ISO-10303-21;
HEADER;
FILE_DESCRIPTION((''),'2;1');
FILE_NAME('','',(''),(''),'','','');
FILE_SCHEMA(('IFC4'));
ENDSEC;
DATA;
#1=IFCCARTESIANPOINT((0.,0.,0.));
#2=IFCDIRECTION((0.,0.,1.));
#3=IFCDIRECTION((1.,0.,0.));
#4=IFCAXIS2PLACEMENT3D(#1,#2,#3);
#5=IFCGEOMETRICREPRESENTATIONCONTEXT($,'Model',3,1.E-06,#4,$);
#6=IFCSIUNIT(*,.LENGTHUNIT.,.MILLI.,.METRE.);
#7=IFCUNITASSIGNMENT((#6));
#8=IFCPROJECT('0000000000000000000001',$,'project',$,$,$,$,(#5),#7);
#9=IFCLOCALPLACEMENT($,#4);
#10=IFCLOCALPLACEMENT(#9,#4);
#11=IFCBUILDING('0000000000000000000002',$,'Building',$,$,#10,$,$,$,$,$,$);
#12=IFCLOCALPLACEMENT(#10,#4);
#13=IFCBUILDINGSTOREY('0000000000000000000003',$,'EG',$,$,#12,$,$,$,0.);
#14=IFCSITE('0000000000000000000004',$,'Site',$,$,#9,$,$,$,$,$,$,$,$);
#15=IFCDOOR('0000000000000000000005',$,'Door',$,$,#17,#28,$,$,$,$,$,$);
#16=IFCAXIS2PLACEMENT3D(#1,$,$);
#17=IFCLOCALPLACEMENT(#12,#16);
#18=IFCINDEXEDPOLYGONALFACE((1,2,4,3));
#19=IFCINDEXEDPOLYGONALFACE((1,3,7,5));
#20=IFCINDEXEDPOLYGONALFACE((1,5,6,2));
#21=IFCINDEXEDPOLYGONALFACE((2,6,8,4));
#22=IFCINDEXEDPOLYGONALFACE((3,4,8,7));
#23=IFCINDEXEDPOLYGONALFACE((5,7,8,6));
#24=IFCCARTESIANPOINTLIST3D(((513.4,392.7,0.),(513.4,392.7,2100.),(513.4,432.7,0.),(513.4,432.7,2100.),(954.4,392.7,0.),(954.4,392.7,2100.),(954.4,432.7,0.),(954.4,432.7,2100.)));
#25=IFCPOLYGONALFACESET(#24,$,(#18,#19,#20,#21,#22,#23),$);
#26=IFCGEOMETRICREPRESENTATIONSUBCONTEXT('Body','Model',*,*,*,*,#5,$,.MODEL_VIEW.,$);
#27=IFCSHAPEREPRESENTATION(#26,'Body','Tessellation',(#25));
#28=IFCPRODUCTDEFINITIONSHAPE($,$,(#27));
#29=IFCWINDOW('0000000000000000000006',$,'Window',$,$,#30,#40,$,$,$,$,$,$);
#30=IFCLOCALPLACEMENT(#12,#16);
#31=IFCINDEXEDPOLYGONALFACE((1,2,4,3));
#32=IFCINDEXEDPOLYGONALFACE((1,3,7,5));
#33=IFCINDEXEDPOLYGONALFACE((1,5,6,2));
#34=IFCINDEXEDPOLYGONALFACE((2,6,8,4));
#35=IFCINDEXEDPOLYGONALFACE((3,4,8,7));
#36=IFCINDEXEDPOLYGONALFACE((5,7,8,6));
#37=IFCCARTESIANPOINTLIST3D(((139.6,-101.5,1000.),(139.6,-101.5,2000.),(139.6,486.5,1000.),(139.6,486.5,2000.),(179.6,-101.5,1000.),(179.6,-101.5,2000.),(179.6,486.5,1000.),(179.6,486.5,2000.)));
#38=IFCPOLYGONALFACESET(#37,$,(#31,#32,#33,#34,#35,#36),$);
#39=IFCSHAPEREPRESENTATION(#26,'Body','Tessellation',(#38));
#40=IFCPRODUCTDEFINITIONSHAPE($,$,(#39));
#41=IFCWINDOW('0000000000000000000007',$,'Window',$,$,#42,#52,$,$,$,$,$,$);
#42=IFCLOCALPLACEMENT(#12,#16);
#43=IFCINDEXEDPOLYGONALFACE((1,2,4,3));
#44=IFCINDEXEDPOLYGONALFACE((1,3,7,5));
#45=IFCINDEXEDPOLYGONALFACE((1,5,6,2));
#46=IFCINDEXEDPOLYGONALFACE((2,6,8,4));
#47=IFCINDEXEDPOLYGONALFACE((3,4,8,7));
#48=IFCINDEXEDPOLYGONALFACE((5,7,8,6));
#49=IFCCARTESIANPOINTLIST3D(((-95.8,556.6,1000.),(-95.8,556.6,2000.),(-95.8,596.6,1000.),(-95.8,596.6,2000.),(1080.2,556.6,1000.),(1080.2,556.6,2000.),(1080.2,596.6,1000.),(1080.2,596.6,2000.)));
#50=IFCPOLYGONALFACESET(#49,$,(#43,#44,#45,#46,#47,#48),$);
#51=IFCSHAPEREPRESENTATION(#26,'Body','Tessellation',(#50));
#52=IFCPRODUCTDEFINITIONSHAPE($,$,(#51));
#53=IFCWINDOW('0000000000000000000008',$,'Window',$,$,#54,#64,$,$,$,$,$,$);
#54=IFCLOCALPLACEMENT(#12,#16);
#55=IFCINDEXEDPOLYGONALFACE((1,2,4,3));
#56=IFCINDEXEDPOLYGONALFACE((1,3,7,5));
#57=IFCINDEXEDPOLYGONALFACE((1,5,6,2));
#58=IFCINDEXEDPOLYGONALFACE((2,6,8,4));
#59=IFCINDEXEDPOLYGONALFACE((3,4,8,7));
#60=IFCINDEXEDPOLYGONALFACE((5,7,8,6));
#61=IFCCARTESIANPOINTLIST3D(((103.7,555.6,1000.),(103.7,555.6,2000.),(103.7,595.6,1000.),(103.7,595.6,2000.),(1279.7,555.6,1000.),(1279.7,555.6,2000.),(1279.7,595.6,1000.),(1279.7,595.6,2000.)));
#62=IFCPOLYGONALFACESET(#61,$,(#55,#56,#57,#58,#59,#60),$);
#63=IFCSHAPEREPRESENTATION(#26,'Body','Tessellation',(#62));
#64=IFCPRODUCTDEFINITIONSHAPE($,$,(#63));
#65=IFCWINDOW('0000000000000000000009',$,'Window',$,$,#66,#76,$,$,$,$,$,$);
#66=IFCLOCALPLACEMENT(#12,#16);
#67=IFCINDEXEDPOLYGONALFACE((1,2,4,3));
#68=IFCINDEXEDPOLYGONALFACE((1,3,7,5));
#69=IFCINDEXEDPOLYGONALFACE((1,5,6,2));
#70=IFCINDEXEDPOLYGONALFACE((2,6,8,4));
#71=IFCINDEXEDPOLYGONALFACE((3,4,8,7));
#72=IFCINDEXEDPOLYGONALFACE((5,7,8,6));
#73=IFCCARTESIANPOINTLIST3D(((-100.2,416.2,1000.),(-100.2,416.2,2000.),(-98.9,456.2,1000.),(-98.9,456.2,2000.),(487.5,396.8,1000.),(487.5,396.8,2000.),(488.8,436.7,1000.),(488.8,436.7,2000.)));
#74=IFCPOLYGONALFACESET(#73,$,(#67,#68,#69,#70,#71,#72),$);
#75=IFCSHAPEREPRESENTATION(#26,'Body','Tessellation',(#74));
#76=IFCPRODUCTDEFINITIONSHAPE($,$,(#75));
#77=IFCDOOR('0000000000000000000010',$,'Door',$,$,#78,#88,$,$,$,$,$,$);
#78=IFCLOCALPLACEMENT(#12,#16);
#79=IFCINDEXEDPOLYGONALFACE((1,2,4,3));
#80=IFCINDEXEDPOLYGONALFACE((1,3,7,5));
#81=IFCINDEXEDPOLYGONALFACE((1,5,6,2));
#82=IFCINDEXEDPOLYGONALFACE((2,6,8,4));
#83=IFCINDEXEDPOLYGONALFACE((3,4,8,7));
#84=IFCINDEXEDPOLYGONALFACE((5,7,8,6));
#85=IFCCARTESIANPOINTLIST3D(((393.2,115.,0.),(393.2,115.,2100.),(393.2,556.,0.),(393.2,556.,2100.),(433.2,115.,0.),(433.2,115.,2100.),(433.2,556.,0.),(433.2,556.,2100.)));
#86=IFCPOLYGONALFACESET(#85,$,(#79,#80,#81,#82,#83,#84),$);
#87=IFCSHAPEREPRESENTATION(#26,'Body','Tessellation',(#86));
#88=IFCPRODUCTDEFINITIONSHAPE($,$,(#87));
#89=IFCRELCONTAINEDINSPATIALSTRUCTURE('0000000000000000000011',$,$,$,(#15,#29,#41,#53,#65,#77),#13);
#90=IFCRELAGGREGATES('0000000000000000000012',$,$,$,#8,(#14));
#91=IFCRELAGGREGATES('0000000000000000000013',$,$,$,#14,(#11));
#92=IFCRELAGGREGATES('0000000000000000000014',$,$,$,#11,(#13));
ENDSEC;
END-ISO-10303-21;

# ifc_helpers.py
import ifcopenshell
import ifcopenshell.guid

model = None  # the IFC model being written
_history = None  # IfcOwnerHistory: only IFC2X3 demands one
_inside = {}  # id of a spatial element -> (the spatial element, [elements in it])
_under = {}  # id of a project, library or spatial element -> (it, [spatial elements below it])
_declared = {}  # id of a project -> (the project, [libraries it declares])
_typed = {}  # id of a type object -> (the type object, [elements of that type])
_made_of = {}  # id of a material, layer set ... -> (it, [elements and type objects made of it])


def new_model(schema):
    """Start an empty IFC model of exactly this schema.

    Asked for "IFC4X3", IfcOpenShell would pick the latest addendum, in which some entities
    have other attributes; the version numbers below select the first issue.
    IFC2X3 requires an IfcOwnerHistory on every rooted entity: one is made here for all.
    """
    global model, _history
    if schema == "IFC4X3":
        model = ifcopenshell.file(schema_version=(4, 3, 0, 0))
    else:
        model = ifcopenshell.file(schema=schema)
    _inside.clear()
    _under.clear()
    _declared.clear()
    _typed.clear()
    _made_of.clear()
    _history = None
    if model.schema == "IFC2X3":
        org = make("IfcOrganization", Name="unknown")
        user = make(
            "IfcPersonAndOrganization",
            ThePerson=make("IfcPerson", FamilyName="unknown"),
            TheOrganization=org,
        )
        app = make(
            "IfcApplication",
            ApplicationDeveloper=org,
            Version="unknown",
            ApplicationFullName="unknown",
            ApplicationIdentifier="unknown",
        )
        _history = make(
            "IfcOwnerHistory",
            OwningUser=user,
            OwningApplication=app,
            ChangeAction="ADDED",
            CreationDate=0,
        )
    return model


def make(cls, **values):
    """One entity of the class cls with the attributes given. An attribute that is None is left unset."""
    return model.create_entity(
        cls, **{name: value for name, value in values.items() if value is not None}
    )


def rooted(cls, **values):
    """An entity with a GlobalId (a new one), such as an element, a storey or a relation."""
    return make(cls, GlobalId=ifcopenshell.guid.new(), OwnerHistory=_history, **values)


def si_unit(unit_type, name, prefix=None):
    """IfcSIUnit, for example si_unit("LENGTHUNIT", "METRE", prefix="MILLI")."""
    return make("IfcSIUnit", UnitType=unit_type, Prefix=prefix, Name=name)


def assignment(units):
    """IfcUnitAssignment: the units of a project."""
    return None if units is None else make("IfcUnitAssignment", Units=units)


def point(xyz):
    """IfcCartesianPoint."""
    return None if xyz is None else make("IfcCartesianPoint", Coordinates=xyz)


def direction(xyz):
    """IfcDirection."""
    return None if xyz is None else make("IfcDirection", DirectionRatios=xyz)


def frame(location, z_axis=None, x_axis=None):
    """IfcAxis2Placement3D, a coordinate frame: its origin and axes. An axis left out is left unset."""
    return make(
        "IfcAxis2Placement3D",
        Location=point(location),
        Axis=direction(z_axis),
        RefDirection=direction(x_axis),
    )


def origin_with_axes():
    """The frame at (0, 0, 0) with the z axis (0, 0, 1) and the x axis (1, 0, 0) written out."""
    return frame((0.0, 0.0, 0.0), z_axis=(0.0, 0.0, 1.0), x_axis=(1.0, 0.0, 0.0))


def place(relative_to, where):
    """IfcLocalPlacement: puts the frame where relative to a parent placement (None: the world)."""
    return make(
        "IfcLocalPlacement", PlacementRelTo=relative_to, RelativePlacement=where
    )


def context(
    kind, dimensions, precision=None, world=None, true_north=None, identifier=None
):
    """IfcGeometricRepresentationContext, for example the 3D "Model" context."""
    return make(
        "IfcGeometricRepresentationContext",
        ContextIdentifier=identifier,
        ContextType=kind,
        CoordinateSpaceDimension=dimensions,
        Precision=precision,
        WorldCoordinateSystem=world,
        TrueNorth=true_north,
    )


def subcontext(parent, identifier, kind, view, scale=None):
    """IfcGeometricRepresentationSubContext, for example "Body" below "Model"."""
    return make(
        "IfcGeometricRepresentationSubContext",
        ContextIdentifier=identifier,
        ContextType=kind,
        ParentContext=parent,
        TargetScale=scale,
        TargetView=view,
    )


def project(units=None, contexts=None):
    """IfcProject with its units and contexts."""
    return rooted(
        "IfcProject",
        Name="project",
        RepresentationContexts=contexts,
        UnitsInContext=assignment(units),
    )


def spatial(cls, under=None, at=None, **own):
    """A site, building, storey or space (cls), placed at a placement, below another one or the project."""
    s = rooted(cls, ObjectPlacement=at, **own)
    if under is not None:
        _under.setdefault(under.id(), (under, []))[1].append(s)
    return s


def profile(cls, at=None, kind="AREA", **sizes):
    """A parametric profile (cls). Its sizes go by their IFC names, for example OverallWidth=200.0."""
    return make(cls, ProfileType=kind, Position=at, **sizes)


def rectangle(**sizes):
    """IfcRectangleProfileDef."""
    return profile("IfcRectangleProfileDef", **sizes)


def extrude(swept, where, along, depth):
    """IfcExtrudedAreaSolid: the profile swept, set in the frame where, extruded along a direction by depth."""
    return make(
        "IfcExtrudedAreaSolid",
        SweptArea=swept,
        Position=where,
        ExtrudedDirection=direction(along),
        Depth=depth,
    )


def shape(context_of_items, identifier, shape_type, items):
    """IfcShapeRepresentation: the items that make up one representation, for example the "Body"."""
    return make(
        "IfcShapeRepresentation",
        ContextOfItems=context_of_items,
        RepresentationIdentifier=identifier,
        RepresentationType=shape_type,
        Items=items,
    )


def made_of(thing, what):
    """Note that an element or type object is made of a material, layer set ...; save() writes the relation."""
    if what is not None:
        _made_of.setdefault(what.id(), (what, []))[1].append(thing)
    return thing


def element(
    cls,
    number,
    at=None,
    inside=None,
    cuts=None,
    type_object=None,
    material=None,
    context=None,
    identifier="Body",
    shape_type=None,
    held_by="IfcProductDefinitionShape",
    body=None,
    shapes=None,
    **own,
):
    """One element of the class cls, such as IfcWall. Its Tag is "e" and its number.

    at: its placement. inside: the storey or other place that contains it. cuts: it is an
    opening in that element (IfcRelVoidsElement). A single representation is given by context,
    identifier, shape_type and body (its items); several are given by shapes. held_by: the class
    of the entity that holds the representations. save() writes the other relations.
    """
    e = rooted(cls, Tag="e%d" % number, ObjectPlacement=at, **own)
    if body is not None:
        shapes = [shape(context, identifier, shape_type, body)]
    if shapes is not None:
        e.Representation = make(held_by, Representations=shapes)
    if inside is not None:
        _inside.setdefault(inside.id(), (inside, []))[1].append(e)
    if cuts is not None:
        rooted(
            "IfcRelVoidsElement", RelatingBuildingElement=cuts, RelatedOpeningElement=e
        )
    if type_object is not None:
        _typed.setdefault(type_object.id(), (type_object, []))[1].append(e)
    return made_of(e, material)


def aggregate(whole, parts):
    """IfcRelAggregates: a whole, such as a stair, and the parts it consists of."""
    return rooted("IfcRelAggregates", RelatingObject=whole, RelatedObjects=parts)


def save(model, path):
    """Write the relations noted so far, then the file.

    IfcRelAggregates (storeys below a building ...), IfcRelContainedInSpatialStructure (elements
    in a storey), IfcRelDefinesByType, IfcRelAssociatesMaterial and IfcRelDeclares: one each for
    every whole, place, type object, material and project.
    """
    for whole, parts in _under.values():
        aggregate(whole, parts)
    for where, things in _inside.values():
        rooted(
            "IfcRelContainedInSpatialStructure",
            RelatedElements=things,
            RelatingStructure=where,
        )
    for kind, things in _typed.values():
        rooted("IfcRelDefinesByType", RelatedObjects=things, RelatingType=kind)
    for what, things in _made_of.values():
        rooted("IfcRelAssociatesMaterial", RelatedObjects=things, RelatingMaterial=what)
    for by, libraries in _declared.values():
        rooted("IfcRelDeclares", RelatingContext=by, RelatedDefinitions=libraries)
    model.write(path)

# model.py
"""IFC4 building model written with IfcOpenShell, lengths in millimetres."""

from ifc_helpers import new_model, si_unit, frame, origin_with_axes, place, context, subcontext, project, spatial, rectangle, extrude, element, save


model = new_model("IFC4")

# Units and contexts
model_context = context("Model", 3, precision=1e-06, world=origin_with_axes())
body_context = subcontext(model_context, "Body", "Model", "MODEL_VIEW")
ifc_project = project(units=[si_unit("LENGTHUNIT", "METRE", prefix="MILLI")], contexts=[model_context])

# Site, building, storey
site_placement = place(None, origin_with_axes())
site = spatial("IfcSite", under=ifc_project, at=site_placement, Name="Site")
building_placement = place(site_placement, origin_with_axes())
building = spatial("IfcBuilding", under=site, at=building_placement, Name="Building")
storey_placement = place(building_placement, origin_with_axes())
storey = spatial("IfcBuildingStorey", under=building, at=storey_placement, Name="EG", Elevation=0.0)

# Door
door_1_placement = place(storey_placement, origin_with_axes())
element("IfcDoor", 1, at=door_1_placement, inside=storey, Name="Door", context=body_context, shape_type="SweptSolid", body=[
    extrude(rectangle(XDim=441.0, YDim=40.0), frame((733.9, 412.7, 0.0), z_axis=(0.0, 0.0, 1.0), x_axis=(-1.0, 0.0, 0.0)), (0.0, 0.0, 1.0), 2100.0),
])

# Windows
window_1_placement = place(storey_placement, origin_with_axes())
element("IfcWindow", 2, at=window_1_placement, inside=storey, Name="Window", context=body_context, shape_type="SweptSolid", body=[
    extrude(rectangle(XDim=588.0, YDim=40.0), frame((159.6, 192.5, 1000.0), z_axis=(0.0, 0.0, 1.0), x_axis=(0.0, 1.0, 0.0)), (0.0, 0.0, 1.0), 1000.0),
])
window_2_placement = place(storey_placement, origin_with_axes())
element("IfcWindow", 3, at=window_2_placement, inside=storey, Name="Window", context=body_context, shape_type="SweptSolid", body=[
    extrude(rectangle(XDim=1176.0, YDim=40.0), frame((492.2, 576.6, 1000.0), z_axis=(0.0, 0.0, 1.0), x_axis=(-1.0, 0.0, 0.0)), (0.0, 0.0, 1.0), 1000.0),
])
window_3_placement = place(storey_placement, origin_with_axes())
element("IfcWindow", 4, at=window_3_placement, inside=storey, Name="Window", context=body_context, shape_type="SweptSolid", body=[
    extrude(rectangle(XDim=1176.0, YDim=40.0), frame((691.7, 575.6, 1000.0), z_axis=(0.0, 0.0, 1.0), x_axis=(-1.0, 0.0, 0.0)), (0.0, 0.0, 1.0), 1000.0),
])
window_4_placement = place(storey_placement, origin_with_axes())
element("IfcWindow", 5, at=window_4_placement, inside=storey, Name="Window", context=body_context, shape_type="SweptSolid", body=[
    extrude(rectangle(XDim=588.0, YDim=40.0), frame((194.3, 426.5, 1000.0), z_axis=(0.0, 0.0, 1.0), x_axis=(0.999454, -0.03304, 0.0)), (0.0, 0.0, 1.0), 1000.0),
])

# Door
door_2_placement = place(storey_placement, origin_with_axes())
element("IfcDoor", 6, at=door_2_placement, inside=storey, Name="Door", context=body_context, shape_type="SweptSolid", body=[
    extrude(rectangle(XDim=441.0, YDim=40.0), frame((413.2, 335.5, 0.0), z_axis=(0.0, 0.0, 1.0), x_axis=(0.0, 1.0, 0.0)), (0.0, 0.0, 1.0), 2100.0),
])

save(model, "model.ifc")
